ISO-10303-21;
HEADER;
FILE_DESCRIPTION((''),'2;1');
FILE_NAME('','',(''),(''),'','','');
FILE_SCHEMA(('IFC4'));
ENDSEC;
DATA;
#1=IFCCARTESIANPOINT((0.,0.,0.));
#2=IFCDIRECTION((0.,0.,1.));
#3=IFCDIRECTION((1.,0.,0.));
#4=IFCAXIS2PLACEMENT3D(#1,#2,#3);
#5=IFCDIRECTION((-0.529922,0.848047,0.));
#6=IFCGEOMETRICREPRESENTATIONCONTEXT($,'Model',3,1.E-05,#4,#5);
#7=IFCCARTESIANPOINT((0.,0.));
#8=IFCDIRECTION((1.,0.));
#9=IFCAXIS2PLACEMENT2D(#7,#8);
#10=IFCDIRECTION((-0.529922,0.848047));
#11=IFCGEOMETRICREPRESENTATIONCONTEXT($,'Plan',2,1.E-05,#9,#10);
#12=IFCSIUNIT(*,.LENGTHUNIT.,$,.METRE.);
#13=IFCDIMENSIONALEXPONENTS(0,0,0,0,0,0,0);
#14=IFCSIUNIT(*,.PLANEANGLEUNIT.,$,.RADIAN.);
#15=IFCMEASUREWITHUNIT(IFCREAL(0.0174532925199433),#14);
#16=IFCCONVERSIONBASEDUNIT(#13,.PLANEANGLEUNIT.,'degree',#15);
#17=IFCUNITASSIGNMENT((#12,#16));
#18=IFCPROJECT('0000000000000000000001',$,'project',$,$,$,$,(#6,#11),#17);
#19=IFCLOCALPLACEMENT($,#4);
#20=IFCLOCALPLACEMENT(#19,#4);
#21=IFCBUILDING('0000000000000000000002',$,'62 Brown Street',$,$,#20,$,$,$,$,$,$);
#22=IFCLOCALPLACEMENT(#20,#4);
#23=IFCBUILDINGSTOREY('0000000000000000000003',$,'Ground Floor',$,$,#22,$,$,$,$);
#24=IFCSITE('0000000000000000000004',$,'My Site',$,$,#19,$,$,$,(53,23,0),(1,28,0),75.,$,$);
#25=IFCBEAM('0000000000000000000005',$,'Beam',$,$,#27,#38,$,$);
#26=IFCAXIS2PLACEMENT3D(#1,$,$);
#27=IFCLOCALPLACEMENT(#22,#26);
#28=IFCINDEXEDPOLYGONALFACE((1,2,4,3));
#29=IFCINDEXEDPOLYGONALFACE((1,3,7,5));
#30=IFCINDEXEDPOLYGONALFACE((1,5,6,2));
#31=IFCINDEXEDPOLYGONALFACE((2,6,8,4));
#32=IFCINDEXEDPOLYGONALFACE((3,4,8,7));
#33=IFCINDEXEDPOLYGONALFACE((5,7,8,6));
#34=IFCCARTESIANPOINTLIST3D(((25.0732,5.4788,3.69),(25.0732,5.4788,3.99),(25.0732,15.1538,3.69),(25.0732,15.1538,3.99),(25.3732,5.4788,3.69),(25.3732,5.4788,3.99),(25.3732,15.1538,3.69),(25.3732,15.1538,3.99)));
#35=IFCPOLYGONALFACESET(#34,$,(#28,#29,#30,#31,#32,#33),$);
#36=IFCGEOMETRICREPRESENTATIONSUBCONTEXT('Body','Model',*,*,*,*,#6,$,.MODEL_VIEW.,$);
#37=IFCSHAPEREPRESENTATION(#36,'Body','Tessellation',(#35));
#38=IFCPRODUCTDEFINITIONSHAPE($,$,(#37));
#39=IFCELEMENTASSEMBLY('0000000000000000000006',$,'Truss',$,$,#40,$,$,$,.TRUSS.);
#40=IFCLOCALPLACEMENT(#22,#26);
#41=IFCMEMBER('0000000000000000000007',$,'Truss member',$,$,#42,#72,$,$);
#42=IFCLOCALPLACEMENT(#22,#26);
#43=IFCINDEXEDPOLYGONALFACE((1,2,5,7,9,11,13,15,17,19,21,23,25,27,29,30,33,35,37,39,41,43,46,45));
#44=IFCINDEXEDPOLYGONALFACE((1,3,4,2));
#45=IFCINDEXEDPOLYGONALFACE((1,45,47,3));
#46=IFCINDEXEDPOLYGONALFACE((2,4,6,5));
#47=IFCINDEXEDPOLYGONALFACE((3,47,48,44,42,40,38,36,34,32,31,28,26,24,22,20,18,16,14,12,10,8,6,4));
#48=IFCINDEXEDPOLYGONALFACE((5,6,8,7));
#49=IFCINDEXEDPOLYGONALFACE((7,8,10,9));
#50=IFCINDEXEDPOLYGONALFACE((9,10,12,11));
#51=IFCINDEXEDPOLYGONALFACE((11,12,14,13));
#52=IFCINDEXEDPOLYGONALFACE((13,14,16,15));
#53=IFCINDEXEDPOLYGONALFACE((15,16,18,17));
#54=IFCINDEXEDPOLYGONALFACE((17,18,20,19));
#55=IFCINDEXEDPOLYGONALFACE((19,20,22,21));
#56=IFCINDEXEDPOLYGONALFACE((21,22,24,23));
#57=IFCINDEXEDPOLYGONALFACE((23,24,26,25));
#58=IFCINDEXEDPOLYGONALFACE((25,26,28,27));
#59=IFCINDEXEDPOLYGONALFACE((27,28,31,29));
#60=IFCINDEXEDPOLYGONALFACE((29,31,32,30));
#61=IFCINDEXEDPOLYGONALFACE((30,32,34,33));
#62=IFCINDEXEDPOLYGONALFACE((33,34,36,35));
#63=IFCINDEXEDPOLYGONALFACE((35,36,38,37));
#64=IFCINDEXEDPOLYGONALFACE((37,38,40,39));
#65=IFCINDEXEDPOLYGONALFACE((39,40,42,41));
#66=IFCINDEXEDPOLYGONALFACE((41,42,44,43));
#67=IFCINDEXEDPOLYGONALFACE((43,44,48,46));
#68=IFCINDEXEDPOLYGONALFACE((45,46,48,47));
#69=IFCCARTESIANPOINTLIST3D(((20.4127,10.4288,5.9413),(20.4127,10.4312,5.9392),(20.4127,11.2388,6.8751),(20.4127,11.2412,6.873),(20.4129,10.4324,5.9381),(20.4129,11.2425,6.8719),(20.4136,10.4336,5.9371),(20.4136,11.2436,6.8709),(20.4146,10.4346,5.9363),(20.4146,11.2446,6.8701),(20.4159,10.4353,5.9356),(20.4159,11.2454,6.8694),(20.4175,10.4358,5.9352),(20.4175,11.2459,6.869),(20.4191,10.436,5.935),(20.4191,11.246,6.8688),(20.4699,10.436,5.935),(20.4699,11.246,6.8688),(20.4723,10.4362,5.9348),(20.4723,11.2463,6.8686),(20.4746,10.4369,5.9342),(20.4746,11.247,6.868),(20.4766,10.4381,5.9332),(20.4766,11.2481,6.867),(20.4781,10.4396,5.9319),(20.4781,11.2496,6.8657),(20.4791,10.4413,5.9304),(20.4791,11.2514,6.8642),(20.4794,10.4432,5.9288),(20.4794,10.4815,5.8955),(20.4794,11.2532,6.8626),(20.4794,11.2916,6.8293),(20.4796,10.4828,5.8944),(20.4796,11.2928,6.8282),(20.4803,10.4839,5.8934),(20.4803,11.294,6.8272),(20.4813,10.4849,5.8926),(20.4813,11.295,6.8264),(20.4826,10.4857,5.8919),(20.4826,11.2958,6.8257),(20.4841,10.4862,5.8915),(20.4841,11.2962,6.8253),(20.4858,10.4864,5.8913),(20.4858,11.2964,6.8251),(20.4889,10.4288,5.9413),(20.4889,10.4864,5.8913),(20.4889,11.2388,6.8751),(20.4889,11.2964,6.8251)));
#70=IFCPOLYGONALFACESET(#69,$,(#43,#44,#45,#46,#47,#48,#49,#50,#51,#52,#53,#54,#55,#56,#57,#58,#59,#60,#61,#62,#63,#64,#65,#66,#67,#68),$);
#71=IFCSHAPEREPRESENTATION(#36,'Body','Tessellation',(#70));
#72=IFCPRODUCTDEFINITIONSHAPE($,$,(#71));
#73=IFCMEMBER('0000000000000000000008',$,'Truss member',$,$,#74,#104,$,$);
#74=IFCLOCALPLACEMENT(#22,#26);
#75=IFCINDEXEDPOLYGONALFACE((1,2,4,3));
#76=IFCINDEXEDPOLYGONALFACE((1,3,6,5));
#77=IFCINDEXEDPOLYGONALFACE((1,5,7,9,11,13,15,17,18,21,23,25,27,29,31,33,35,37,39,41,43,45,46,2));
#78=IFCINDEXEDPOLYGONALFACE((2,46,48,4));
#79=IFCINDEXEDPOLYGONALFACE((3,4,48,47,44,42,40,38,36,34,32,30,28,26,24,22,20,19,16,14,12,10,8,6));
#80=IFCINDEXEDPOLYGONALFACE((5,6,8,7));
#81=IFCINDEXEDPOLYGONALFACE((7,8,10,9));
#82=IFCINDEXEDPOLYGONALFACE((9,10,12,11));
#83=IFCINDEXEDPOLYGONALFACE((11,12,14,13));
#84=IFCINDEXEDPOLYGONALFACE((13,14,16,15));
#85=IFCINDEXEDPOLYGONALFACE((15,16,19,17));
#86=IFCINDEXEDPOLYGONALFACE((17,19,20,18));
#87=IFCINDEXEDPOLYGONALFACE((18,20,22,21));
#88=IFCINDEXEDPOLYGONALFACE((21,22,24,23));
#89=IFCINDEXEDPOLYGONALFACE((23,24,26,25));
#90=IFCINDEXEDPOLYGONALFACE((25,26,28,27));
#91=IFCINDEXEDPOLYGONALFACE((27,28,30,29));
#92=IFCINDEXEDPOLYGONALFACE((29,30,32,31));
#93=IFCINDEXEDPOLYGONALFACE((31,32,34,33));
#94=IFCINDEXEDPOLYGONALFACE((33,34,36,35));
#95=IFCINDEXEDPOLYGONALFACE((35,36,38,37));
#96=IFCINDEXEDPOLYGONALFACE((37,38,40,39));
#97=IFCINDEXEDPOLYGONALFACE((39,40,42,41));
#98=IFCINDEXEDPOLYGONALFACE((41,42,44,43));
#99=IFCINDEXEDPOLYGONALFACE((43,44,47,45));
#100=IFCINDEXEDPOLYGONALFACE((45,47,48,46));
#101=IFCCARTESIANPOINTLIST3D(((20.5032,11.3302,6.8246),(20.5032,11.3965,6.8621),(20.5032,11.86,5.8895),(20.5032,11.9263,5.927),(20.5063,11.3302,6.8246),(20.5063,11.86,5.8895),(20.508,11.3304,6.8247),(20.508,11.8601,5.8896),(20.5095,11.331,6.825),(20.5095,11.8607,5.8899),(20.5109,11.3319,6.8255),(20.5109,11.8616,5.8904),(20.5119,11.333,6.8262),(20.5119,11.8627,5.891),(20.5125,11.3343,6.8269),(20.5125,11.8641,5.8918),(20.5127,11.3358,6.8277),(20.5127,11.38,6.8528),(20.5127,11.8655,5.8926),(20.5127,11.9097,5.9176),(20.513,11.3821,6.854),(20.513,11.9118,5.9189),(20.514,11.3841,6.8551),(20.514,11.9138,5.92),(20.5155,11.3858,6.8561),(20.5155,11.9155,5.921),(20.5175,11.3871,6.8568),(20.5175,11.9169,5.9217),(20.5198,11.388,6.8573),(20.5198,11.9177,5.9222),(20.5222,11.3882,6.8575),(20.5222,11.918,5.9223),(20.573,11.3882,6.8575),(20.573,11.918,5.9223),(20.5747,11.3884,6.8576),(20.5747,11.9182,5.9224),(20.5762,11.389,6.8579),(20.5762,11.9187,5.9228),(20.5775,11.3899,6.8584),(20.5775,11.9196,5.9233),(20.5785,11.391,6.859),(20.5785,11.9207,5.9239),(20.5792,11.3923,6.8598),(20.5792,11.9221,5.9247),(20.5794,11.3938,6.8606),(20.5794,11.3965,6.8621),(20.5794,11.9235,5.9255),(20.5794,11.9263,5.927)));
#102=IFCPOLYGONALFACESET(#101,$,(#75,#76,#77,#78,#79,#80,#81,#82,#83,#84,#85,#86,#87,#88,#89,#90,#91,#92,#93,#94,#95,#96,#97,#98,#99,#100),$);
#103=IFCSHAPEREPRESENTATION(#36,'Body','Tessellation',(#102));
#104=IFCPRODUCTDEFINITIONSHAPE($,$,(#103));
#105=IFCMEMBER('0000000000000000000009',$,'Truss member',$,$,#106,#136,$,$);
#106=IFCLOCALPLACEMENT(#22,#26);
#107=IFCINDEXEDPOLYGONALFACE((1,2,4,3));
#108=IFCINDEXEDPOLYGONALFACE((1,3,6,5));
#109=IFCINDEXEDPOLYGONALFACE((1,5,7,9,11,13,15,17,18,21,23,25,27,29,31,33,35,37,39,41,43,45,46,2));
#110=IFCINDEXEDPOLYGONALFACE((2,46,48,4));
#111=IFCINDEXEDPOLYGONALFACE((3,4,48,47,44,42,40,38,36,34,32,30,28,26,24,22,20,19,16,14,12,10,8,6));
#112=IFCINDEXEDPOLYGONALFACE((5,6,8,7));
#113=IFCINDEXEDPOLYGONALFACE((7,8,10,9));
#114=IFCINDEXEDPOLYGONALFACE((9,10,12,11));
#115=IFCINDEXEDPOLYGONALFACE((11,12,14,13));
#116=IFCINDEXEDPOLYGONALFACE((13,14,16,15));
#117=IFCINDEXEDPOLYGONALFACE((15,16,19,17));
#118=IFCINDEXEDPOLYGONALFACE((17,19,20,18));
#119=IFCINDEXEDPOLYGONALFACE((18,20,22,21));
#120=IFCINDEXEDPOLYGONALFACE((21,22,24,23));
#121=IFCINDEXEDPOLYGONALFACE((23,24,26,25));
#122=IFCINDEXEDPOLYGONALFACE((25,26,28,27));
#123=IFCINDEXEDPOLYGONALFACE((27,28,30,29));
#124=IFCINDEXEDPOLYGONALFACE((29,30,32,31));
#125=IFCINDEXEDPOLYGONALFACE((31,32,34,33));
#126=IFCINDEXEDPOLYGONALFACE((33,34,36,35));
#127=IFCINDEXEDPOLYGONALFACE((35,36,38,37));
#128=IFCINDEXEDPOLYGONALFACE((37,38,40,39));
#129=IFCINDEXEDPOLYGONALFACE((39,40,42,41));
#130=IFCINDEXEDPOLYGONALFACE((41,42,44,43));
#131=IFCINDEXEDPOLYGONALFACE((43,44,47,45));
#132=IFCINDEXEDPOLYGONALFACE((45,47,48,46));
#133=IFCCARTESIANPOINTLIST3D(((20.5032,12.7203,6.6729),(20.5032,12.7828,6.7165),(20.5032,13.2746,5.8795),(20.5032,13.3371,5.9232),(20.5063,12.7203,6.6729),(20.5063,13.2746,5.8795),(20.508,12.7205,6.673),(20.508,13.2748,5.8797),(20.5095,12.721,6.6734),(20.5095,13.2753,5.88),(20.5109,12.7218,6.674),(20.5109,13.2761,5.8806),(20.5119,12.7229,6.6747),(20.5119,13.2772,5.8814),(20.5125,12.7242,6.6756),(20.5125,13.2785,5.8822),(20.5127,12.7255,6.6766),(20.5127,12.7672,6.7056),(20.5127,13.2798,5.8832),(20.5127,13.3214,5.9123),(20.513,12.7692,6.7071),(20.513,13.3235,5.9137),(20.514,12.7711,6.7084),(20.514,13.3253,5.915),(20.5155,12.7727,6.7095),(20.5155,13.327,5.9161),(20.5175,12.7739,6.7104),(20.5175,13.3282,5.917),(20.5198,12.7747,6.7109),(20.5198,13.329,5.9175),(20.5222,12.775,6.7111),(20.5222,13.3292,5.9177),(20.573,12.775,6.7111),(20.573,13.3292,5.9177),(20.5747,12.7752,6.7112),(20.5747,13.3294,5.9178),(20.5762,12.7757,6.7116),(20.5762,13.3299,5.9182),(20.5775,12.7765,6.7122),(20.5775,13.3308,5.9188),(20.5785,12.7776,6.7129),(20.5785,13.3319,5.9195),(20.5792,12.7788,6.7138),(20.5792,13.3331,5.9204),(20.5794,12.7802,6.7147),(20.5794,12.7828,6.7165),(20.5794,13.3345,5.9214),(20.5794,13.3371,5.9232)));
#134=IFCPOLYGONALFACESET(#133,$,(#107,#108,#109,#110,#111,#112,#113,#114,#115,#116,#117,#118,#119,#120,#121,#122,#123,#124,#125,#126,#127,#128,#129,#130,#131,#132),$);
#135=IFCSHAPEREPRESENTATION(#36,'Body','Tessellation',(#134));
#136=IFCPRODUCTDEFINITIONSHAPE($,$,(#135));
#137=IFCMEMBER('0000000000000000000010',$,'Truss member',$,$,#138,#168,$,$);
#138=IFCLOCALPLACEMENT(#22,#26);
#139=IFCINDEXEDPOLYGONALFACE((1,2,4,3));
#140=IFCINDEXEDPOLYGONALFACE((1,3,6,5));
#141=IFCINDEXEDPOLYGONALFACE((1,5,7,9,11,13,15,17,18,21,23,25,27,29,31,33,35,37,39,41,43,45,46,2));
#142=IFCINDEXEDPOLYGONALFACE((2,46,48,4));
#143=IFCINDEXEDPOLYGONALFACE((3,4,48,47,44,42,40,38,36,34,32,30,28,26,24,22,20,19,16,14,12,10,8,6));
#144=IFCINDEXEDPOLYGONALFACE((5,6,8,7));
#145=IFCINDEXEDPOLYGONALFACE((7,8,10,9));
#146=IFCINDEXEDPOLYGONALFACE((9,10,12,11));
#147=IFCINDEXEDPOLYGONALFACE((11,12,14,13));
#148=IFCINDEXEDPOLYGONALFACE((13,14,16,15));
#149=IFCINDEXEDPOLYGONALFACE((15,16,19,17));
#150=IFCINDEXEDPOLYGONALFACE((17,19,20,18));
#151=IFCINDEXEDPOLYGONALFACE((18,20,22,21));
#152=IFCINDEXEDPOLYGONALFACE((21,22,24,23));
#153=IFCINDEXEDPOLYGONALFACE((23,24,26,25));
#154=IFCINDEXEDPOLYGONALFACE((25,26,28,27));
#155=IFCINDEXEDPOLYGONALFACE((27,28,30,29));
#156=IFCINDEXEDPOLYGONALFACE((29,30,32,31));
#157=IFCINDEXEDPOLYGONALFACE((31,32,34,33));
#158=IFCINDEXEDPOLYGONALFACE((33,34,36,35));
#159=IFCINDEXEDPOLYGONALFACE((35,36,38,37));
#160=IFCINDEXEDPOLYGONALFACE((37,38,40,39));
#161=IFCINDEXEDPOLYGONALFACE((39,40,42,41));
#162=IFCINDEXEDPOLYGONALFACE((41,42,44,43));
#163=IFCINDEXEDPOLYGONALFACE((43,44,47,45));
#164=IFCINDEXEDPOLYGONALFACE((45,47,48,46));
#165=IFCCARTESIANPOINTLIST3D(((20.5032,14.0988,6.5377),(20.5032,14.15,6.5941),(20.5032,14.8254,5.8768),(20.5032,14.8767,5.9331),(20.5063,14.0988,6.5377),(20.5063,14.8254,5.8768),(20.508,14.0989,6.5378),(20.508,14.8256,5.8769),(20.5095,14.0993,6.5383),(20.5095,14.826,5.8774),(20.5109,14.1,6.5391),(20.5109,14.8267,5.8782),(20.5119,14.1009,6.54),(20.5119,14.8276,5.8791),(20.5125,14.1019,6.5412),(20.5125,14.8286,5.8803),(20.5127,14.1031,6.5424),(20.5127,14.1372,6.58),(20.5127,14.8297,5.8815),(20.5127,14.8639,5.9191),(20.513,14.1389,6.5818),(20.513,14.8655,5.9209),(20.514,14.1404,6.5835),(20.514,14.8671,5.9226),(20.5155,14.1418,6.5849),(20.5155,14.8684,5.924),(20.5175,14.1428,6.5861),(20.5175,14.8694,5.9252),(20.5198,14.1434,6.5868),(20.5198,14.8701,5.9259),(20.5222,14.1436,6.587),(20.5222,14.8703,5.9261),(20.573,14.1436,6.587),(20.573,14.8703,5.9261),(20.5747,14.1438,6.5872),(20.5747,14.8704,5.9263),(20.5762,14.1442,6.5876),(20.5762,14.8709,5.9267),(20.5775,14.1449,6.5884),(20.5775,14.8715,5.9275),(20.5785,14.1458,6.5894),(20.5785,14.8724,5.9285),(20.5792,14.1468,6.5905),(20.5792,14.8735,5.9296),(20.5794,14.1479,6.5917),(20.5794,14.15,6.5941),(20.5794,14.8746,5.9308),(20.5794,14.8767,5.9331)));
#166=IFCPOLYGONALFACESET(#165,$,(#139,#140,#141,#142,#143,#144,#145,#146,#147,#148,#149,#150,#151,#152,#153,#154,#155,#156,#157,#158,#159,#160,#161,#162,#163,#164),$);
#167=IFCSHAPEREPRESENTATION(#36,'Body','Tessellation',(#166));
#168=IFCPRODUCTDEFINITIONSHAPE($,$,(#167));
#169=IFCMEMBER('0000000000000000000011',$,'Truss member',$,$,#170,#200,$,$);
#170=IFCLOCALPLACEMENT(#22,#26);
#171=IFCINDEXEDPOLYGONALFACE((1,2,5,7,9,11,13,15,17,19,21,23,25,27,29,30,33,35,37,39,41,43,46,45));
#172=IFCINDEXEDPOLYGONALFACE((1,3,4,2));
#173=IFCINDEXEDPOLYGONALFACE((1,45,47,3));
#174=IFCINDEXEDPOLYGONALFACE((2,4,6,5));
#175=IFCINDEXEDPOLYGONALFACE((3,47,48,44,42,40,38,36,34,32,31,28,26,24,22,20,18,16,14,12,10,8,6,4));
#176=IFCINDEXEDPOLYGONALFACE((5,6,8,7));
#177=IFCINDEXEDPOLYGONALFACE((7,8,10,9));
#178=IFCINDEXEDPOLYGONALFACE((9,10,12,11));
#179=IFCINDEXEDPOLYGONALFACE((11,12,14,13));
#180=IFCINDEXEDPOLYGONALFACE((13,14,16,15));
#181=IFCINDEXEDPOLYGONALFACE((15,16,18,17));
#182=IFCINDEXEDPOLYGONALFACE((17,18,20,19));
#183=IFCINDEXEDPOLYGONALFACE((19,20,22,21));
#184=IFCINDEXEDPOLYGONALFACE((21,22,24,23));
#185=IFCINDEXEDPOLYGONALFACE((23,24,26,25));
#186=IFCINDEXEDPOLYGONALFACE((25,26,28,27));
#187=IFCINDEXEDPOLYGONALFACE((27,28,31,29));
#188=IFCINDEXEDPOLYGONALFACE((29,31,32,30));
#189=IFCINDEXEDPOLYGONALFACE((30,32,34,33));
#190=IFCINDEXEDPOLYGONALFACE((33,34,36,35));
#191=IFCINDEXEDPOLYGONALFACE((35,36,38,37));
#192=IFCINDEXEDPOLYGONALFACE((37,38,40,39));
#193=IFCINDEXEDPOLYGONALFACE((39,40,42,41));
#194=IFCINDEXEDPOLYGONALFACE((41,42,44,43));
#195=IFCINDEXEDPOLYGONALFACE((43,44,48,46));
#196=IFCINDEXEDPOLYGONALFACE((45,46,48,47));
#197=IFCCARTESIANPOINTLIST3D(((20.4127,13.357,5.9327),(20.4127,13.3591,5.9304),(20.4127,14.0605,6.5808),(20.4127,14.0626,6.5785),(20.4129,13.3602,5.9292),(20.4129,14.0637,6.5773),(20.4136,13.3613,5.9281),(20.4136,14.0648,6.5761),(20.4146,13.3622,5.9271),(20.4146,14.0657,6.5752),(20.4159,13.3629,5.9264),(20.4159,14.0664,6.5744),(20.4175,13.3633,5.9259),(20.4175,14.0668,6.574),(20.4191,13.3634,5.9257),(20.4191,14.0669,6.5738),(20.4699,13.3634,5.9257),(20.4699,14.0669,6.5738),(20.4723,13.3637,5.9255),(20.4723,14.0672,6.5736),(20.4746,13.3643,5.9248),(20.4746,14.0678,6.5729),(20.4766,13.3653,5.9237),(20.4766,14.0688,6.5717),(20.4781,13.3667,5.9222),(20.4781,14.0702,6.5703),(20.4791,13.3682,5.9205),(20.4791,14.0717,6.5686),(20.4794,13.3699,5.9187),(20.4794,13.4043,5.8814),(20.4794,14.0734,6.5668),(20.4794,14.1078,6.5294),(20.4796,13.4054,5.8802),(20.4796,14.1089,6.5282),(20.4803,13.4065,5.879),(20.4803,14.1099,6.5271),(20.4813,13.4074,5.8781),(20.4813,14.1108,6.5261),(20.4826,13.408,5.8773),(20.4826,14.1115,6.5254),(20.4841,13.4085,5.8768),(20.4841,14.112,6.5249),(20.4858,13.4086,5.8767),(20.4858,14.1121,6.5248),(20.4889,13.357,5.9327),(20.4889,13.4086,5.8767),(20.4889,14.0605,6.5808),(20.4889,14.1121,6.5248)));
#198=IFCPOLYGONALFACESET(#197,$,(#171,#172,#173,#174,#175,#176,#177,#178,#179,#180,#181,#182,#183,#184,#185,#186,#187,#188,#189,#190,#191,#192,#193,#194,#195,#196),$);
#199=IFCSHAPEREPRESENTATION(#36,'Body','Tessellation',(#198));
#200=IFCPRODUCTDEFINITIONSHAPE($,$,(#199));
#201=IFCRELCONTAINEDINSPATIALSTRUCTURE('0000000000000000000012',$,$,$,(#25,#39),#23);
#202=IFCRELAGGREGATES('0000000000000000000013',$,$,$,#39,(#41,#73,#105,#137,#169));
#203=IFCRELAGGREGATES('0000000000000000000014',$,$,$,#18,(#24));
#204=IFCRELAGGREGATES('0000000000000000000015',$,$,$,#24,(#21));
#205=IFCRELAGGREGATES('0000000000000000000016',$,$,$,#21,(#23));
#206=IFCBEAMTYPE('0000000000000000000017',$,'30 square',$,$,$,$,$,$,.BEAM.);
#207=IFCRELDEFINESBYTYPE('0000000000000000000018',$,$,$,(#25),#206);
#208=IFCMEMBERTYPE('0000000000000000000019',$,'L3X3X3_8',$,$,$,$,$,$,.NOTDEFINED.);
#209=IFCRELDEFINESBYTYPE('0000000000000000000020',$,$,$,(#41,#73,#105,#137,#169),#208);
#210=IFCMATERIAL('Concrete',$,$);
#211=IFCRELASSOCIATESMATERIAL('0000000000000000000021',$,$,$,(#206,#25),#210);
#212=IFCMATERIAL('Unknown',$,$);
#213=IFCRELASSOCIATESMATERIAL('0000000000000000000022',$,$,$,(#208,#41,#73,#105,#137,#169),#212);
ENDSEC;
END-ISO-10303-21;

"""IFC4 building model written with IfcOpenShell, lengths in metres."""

from ifc_helpers import new_model, entity, si_unit, converted_unit, direction, frame, origin_with_axes, origin_2d_with_axis, place, context, subcontext, project, spatial, rectangle, l_section, extrude, material, material_profile, profile_set, profile_usage, type_object, element, aggregate, save


model = new_model("IFC4")

# Units and contexts
model_context = context("Model", 3, precision=1e-05, world=origin_with_axes(), true_north=direction((-0.529922, 0.848047, 0.0)))
plan_context = context("Plan", 2, precision=1e-05, world=origin_2d_with_axis(), true_north=direction((-0.529922, 0.848047)))
body_context_1 = subcontext(model_context, "Body", "Model", "MODEL_VIEW")
ifc_project = project(units=[si_unit("LENGTHUNIT", "METRE"), converted_unit("PLANEANGLEUNIT", "degree", entity("IfcReal", 0.0174532925199433), si_unit("PLANEANGLEUNIT", "RADIAN"), dimensions=[0, 0, 0, 0, 0, 0, 0])], contexts=[model_context, plan_context])

# Site, building, storey
site_placement = place(None, origin_with_axes())
site = spatial("IfcSite", under=ifc_project, at=site_placement, Name="My Site", RefLatitude=(53, 23, 0), RefLongitude=(1, 28, 0), RefElevation=75.0)
building_placement = place(site_placement, origin_with_axes())
building = spatial("IfcBuilding", under=site, at=building_placement, Name="62 Brown Street")
storey_placement = place(building_placement, origin_with_axes())
storey = spatial("IfcBuildingStorey", under=building, at=storey_placement, Name="Ground Floor")

# Shared definitions
ifc_material_1 = material(Name="Concrete")

# Beam
ifc_material_profile_1 = material_profile(ifc_material_1, rectangle(XDim=0.3, YDim=0.3))
ifc_profile_set_1 = profile_set([ifc_material_profile_1])
ifc_profile_usage_1 = profile_usage(ifc_profile_set_1, cardinal=5)
beam_type = type_object("IfcBeamType", Name="30 square", PredefinedType="BEAM", material=ifc_profile_set_1)
beam_placement = place(storey_placement, frame((25.2232, 5.4788, 3.84), z_axis=(0.0, 1.0, 0.0), x_axis=(-1.0, 0.0, 0.0)))
element("IfcBeam", 1, at=beam_placement, inside=storey, type_object=beam_type, material=ifc_profile_usage_1, Name="Beam", context=body_context_1, shape_type="SweptSolid", body=[
    extrude(rectangle(XDim=0.3, YDim=0.3), origin_with_axes(), (0.0, 0.0, 1.0), 9.675),
])

# Element assembly, members
assembly_placement = place(storey_placement, frame((20.5032, 10.4288, 6.9738), z_axis=(0.0, 0.0, 1.0), x_axis=(1.0, 0.0, 0.0)))
assembly = element("IfcElementAssembly", 2, at=assembly_placement, inside=storey, Name="Truss", PredefinedType="TRUSS")
ifc_material_2 = material(Name="Unknown")
ifc_material_profile_2 = material_profile(ifc_material_2, l_section(Depth=0.0762, Width=0.0762, Thickness=0.0095, FilletRadius=0.0095, EdgeRadius=0.0064))
ifc_profile_set_2 = profile_set([ifc_material_profile_2])
ifc_profile_usage_2 = profile_usage(ifc_profile_set_2, cardinal=5)
member_type_1 = type_object("IfcMemberType", Name="L3X3X3_8", PredefinedType="NOTDEFINED", material=ifc_profile_set_2)
member_1_placement = place(assembly_placement, frame((-0.0524, 0.8388, -0.1236), z_axis=(0.000001, -0.655276, -0.755389), x_axis=(-1.0, -0.000001, 0.0)))
member_1 = element("IfcMember", 3, at=member_1_placement, type_object=member_type_1, material=ifc_profile_usage_2, Name="Truss member", context=body_context_1, shape_type="SweptSolid", body=[
    extrude(l_section(Depth=0.0762, Width=0.0762, Thickness=0.0095, FilletRadius=0.0095, EdgeRadius=0.0064), origin_with_axes(), (0.0, 0.0, 1.0), 1.2362),
])
ifc_profile_usage_3 = profile_usage(ifc_profile_set_2, cardinal=5)
member_2_placement = place(assembly_placement, frame((0.0381, 0.9346, -0.1304), z_axis=(0.0, 0.492899, -0.870086), x_axis=(1.0, 0.0, 0.0)))
member_2 = element("IfcMember", 4, at=member_2_placement, type_object=member_type_1, material=ifc_profile_usage_3, Name="Truss member", context=body_context_1, shape_type="SweptSolid", body=[
    extrude(l_section(Depth=0.0762, Width=0.0762, Thickness=0.0095, FilletRadius=0.0095, EdgeRadius=0.0064), origin_with_axes(), (0.0, 0.0, 1.0), 1.0747),
])
ifc_profile_usage_4 = profile_usage(ifc_profile_set_2, cardinal=5)
member_3_placement = place(assembly_placement, frame((0.0381, 2.3228, -0.279), z_axis=(-0.000001, 0.572709, -0.819759), x_axis=(1.0, 0.0, 0.0)))
member_3 = element("IfcMember", 5, at=member_3_placement, type_object=member_type_1, material=ifc_profile_usage_4, Name="Truss member", context=body_context_1, shape_type="SweptSolid", body=[
    extrude(l_section(Depth=0.0762, Width=0.0762, Thickness=0.0095, FilletRadius=0.0095, EdgeRadius=0.0064), origin_with_axes(), (0.0, 0.0, 1.0), 0.9678),
])
ifc_profile_usage_5 = profile_usage(ifc_profile_set_2, cardinal=5)
member_4_placement = place(assembly_placement, frame((0.0381, 3.6956, -0.4079), z_axis=(-0.000001, 0.739785, -0.672843), x_axis=(1.0, 0.000001, 0.0)))
member_4 = element("IfcMember", 6, at=member_4_placement, type_object=member_type_1, material=ifc_profile_usage_5, Name="Truss member", context=body_context_1, shape_type="SweptSolid", body=[
    extrude(l_section(Depth=0.0762, Width=0.0762, Thickness=0.0095, FilletRadius=0.0095, EdgeRadius=0.0064), origin_with_axes(), (0.0, 0.0, 1.0), 0.9823),
])
ifc_profile_usage_6 = profile_usage(ifc_profile_set_2, cardinal=5)
member_5_placement = place(assembly_placement, frame((-0.0524, 3.6575, -0.421), z_axis=(0.000001, -0.735484, -0.677542), x_axis=(-1.0, -0.000001, 0.0)))
member_5 = element("IfcMember", 7, at=member_5_placement, type_object=member_type_1, material=ifc_profile_usage_6, Name="Truss member", context=body_context_1, shape_type="SweptSolid", body=[
    extrude(l_section(Depth=0.0762, Width=0.0762, Thickness=0.0095, FilletRadius=0.0095, EdgeRadius=0.0064), origin_with_axes(), (0.0, 0.0, 1.0), 0.9565),
])

aggregate(assembly, [member_1, member_2, member_3, member_4, member_5])

save(model, "model.ifc")
